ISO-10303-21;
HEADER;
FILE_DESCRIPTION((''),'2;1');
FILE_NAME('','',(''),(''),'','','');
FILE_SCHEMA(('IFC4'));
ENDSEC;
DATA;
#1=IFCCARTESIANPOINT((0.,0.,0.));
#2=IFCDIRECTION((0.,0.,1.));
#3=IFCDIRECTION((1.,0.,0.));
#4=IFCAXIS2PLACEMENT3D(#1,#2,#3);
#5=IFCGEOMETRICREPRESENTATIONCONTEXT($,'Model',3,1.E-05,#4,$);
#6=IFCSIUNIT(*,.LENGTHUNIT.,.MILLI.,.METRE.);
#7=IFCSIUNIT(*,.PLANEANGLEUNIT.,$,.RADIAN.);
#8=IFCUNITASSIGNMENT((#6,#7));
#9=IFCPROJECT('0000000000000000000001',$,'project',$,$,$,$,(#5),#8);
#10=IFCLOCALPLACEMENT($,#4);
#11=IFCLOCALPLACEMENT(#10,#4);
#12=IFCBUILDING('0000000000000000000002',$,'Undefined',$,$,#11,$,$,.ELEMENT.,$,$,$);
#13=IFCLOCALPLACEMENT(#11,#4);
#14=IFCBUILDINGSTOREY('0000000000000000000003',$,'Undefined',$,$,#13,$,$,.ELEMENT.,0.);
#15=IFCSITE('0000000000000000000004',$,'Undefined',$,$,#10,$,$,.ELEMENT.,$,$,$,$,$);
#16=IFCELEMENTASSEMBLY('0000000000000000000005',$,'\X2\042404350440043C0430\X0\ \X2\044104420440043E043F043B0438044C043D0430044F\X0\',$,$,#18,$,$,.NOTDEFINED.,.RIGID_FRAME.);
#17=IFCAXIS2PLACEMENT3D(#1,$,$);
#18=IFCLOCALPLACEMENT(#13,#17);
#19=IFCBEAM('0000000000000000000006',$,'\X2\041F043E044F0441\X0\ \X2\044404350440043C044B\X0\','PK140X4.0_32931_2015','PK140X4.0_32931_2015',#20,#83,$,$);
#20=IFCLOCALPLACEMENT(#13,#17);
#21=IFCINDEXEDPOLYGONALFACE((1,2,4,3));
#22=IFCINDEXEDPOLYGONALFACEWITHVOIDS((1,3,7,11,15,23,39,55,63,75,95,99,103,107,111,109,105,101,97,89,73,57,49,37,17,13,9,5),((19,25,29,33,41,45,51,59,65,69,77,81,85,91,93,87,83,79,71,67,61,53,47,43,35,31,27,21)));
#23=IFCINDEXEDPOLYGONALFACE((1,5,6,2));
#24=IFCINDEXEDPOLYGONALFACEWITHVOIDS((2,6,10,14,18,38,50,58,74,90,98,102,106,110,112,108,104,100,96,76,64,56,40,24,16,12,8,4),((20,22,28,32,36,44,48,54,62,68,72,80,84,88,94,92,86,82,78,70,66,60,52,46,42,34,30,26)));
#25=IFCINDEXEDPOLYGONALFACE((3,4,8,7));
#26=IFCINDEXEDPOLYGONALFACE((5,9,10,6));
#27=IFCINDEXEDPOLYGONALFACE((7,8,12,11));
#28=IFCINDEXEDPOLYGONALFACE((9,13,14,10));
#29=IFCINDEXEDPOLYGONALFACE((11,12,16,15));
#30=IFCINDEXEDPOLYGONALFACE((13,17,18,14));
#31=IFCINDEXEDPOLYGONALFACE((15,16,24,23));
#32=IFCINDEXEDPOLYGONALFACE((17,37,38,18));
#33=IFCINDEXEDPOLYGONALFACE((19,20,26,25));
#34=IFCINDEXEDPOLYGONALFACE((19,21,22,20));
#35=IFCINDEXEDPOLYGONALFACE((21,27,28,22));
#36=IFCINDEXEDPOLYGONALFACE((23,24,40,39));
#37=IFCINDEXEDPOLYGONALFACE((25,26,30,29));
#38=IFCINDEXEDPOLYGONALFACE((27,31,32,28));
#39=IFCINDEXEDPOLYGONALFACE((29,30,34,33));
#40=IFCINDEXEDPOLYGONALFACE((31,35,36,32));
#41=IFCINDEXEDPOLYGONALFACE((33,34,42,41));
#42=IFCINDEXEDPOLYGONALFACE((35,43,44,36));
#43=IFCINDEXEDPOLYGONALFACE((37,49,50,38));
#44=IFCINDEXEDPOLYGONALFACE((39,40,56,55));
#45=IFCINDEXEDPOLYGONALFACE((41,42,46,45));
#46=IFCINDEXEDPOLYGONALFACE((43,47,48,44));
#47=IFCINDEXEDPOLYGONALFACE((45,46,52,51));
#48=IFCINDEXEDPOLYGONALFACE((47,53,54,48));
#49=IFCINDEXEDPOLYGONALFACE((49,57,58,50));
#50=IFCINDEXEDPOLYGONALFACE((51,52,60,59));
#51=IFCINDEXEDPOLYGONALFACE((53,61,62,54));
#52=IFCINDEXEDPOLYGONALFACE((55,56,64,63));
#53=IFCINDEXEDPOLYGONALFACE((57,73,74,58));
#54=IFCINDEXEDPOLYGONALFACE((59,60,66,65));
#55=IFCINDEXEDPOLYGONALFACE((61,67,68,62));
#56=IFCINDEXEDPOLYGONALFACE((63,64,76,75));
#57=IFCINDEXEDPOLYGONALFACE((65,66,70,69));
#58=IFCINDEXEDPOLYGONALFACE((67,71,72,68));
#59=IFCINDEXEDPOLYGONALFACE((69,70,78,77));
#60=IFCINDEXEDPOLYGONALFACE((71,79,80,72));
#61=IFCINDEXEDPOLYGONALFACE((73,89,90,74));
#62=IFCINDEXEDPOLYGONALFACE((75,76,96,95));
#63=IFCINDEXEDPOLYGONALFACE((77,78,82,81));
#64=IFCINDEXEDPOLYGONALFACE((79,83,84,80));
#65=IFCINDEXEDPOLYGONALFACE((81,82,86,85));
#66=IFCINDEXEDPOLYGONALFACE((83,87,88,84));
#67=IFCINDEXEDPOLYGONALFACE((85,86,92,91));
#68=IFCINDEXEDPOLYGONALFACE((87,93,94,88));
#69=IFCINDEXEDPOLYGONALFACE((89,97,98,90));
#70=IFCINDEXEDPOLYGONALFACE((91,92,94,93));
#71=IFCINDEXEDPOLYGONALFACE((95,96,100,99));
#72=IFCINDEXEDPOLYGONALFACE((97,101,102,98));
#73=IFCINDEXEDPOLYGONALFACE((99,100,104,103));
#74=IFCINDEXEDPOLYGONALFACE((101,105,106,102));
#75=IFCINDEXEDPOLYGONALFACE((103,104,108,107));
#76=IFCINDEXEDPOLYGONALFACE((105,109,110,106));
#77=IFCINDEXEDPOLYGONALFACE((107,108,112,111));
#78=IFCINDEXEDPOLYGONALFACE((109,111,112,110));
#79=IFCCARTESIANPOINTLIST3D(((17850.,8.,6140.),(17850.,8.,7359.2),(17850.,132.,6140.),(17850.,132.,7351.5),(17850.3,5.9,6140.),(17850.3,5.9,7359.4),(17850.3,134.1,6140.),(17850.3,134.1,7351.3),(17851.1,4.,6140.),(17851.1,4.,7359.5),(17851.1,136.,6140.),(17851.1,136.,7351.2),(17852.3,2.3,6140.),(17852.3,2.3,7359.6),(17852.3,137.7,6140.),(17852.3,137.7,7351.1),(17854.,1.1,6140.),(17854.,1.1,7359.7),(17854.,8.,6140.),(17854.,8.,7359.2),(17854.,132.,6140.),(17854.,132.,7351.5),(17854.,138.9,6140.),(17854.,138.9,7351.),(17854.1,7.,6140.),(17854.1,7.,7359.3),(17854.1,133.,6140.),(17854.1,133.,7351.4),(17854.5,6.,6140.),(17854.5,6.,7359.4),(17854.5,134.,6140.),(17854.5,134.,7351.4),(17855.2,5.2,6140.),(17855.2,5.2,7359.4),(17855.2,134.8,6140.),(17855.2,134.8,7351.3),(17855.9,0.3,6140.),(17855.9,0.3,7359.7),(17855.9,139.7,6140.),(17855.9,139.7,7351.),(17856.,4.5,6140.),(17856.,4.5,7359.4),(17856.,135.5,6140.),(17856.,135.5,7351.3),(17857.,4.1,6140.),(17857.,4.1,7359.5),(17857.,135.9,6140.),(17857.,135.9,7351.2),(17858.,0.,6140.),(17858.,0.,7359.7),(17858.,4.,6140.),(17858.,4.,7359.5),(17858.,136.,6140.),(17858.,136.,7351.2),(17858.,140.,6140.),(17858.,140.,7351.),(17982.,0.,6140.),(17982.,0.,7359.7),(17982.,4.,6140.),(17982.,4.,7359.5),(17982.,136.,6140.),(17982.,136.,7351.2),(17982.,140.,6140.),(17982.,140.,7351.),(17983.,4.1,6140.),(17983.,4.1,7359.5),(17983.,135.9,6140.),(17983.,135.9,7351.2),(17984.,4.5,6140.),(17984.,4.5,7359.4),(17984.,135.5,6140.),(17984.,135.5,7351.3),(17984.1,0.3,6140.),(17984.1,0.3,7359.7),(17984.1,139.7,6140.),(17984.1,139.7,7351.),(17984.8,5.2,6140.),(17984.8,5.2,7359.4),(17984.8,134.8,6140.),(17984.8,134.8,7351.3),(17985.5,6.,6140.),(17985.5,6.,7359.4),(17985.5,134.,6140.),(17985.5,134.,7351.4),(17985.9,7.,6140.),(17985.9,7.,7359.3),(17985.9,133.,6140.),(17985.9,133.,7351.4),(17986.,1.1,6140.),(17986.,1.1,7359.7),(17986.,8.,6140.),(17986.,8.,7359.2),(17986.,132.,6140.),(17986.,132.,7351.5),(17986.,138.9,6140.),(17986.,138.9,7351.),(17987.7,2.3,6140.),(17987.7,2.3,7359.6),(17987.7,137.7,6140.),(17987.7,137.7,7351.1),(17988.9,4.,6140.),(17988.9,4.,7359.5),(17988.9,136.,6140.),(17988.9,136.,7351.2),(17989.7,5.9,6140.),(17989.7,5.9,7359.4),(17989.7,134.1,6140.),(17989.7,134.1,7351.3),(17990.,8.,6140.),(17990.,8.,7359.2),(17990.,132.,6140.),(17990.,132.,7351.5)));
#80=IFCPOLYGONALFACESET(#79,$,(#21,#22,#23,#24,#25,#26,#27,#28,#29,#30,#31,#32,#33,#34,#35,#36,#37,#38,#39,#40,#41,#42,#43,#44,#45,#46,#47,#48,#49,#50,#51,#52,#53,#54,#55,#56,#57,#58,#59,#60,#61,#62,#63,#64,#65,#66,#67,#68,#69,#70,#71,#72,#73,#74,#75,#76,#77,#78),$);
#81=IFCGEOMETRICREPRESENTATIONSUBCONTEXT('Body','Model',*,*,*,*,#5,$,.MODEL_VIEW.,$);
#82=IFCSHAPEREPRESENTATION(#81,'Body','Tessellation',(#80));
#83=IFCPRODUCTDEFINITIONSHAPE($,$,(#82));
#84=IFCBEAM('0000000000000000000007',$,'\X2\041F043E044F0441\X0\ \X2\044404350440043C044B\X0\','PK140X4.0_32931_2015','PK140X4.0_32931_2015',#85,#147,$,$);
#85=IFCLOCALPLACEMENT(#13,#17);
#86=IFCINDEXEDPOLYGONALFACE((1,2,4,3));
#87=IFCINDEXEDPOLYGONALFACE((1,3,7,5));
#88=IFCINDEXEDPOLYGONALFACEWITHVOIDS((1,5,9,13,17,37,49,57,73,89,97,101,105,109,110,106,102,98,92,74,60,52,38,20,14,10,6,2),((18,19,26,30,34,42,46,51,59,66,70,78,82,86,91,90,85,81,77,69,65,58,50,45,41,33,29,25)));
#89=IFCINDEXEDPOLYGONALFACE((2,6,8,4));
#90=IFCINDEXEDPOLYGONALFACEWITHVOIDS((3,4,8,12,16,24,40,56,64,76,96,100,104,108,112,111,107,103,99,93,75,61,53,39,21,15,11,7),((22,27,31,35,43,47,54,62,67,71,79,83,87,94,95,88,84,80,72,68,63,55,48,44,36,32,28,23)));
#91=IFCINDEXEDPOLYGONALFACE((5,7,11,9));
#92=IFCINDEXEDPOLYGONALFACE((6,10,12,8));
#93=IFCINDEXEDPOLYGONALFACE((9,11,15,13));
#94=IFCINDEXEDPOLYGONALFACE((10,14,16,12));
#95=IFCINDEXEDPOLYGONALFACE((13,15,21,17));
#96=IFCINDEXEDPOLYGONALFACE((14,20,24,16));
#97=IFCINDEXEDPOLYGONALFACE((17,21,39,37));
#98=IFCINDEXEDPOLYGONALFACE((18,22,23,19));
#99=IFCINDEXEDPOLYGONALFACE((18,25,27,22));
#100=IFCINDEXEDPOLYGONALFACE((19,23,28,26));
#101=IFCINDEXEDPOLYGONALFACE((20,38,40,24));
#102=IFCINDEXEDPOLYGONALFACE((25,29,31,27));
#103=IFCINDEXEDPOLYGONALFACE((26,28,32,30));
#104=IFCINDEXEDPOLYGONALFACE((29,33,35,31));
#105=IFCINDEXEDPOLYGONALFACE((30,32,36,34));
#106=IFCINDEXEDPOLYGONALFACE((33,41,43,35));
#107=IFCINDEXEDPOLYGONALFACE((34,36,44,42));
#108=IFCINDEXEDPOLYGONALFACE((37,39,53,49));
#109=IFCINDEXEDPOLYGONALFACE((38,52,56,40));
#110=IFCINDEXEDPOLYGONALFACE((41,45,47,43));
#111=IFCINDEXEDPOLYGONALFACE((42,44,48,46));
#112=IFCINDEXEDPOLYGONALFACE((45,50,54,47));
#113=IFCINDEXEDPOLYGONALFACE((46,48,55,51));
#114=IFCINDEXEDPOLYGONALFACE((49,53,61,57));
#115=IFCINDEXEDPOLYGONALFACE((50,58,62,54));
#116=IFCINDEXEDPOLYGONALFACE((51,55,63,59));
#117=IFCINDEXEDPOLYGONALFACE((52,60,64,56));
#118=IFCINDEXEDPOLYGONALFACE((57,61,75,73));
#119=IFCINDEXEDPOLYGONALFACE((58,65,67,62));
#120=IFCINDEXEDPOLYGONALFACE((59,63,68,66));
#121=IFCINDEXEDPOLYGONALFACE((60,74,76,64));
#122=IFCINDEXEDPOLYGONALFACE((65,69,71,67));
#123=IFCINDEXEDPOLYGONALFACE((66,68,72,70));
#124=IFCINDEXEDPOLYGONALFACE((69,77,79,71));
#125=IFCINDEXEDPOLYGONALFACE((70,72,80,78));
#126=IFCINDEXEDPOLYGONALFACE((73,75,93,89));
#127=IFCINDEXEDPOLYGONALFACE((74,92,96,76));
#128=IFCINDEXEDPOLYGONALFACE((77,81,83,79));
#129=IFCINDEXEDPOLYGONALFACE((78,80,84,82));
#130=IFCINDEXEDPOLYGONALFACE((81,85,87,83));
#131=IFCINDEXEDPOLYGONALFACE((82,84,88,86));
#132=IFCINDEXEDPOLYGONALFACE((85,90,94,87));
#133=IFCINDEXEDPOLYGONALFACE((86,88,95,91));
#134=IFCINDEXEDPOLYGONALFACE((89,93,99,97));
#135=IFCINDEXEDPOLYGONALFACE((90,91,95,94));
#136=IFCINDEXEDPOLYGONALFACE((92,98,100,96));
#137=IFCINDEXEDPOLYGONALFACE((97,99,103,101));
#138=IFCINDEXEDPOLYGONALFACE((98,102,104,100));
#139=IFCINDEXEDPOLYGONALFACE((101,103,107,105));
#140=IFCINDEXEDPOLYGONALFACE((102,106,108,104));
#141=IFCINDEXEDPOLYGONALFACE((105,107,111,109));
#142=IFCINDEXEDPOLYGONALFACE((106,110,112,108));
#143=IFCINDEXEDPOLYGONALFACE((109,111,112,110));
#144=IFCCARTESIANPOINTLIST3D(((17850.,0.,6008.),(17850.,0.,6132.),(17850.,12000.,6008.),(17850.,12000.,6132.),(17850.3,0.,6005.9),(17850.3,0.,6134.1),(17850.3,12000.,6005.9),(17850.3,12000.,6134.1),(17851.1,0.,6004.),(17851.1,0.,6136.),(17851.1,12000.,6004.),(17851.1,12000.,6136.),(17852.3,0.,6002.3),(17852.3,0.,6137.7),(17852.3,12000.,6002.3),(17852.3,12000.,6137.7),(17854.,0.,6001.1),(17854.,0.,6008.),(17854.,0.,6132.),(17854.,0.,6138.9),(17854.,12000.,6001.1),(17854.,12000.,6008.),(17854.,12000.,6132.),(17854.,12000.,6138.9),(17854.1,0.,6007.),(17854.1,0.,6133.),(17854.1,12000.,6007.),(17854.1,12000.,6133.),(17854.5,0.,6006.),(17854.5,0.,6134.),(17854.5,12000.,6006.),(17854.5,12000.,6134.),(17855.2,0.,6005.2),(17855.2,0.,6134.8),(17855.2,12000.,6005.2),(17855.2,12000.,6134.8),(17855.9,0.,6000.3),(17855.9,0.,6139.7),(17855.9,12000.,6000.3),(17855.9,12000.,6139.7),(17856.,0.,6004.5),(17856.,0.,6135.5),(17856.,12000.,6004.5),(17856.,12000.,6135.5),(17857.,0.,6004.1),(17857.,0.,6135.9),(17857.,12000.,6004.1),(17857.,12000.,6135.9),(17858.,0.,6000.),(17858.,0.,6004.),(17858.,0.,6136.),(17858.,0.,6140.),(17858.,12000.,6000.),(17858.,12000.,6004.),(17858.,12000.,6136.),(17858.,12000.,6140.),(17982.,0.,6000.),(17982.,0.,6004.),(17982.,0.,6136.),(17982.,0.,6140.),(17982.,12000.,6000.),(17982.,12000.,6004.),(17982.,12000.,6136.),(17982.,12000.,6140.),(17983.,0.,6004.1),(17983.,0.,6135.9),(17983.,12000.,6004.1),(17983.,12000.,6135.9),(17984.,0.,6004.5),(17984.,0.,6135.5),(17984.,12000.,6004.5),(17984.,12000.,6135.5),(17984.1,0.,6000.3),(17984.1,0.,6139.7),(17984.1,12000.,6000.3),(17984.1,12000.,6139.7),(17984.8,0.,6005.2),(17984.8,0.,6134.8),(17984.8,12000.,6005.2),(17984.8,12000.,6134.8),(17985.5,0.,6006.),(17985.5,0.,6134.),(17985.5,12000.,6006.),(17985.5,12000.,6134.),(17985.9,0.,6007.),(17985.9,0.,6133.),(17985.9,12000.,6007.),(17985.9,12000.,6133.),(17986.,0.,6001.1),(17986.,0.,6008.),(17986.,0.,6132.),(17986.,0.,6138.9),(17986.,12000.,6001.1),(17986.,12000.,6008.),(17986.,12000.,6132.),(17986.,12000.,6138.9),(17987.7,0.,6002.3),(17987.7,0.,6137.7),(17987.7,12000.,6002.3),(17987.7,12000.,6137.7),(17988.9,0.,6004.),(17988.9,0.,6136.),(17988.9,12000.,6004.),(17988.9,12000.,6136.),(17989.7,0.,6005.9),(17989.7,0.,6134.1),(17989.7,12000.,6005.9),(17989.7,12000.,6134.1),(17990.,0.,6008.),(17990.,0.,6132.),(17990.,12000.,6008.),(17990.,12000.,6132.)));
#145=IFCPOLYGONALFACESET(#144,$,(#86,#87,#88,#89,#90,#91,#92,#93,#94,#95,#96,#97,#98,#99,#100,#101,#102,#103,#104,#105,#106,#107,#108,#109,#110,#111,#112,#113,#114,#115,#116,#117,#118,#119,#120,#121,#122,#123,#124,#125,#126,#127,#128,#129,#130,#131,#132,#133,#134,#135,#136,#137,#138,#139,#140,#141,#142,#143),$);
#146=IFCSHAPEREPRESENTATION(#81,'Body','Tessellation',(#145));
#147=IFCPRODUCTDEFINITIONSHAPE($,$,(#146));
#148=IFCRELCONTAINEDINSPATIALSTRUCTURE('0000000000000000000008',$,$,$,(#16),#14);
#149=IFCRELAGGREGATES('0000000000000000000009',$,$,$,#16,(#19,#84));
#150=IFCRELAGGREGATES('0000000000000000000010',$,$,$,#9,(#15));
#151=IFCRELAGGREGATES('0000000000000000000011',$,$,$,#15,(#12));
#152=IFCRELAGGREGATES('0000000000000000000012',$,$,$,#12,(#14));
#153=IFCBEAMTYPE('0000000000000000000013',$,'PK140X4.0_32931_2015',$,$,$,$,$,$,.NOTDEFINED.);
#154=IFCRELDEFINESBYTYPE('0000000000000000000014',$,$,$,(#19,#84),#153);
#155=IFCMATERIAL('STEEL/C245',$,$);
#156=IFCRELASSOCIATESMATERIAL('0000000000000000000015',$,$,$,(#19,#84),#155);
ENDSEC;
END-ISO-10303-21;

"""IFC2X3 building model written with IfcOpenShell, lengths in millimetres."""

from ifc_helpers import new_model, si_unit, frame, origin_with_axes, origin_2d_with_axis, place, context, subcontext, project, spatial, hollow_rectangle, extrude, clip, halfspace, material, type_object, element, aggregate, save


model = new_model("IFC2X3")

# Units and contexts
model_context = context("Model", 3, precision=1e-05, world=origin_with_axes())
body_context = subcontext(model_context, "Body", "Model", "MODEL_VIEW")
ifc_project = project(units=[si_unit("LENGTHUNIT", "METRE", prefix="MILLI"), si_unit("PLANEANGLEUNIT", "RADIAN")], contexts=[model_context])

# Site, building, storey
site_placement = place(None, origin_with_axes())
site = spatial("IfcSite", under=ifc_project, at=site_placement, Name="Undefined", CompositionType="ELEMENT")
building_placement = place(site_placement, origin_with_axes())
building = spatial("IfcBuilding", under=site, at=building_placement, Name="Undefined", CompositionType="ELEMENT")
storey_placement = place(building_placement, origin_with_axes())
storey = spatial("IfcBuildingStorey", under=building, at=storey_placement, Name="Undefined", CompositionType="ELEMENT", Elevation=0.0)

# Shared definitions
ifc_material = material(Name="STEEL/C245")

# Element assembly, beams
assembly_1_placement = place(storey_placement, origin_with_axes())
assembly_1 = element("IfcElementAssembly", 1, at=assembly_1_placement, inside=storey, Name="Ферма строплиьная", AssemblyPlace="NOTDEFINED", PredefinedType="RIGID_FRAME")
beam_type_1 = type_object("IfcBeamType", Name="PK140X4.0_32931_2015", PredefinedType="NOTDEFINED")
beam_1_placement = place(assembly_1_placement, frame((17920.0, 70.0, 7359.7), z_axis=(1.0, 0.0, 0.0), x_axis=(0.0, 0.0, -1.0)))
beam_1 = element("IfcBeam", 2, at=beam_1_placement, type_object=beam_type_1, material=ifc_material, Name="Пояс фермы", Description="PK140X4.0_32931_2015", ObjectType="PK140X4.0_32931_2015", context=body_context, shape_type="Clipping", body=[
    clip(extrude(hollow_rectangle(XDim=140.0, YDim=140.0, WallThickness=4.0, InnerFilletRadius=4.0, OuterFilletRadius=8.0, at=origin_2d_with_axis()), frame((1219.7, 0.0, 0.0), z_axis=(-1.0, 0.0, 0.0), x_axis=(0.0, -1.0, 0.0)), (0.0, 0.0, 1.0), 1219.8), halfspace(frame((10.5, 98.4, 0.0), z_axis=(0.998053, -0.062378, 0.0), x_axis=(0.0, 0.0, 1.0)), True)),
])
beam_2_placement = place(assembly_1_placement, frame((17920.0, 0.0, 6070.0), z_axis=(0.0, 0.0, 1.0), x_axis=(0.0, 1.0, 0.0)))
beam_2 = element("IfcBeam", 3, at=beam_2_placement, type_object=beam_type_1, material=ifc_material, Name="Пояс фермы", Description="PK140X4.0_32931_2015", ObjectType="PK140X4.0_32931_2015", context=body_context, shape_type="SweptSolid", body=[
    extrude(hollow_rectangle(XDim=140.0, YDim=140.0, WallThickness=4.0, InnerFilletRadius=4.0, OuterFilletRadius=8.0, at=origin_2d_with_axis()), frame((12000.0, 0.0, 0.0), z_axis=(-1.0, 0.0, 0.0), x_axis=(0.0, -1.0, 0.0)), (0.0, 0.0, 1.0), 12000.0),
])
aggregate(assembly_1, [beam_1, beam_2])

save(model, "model.ifc")
